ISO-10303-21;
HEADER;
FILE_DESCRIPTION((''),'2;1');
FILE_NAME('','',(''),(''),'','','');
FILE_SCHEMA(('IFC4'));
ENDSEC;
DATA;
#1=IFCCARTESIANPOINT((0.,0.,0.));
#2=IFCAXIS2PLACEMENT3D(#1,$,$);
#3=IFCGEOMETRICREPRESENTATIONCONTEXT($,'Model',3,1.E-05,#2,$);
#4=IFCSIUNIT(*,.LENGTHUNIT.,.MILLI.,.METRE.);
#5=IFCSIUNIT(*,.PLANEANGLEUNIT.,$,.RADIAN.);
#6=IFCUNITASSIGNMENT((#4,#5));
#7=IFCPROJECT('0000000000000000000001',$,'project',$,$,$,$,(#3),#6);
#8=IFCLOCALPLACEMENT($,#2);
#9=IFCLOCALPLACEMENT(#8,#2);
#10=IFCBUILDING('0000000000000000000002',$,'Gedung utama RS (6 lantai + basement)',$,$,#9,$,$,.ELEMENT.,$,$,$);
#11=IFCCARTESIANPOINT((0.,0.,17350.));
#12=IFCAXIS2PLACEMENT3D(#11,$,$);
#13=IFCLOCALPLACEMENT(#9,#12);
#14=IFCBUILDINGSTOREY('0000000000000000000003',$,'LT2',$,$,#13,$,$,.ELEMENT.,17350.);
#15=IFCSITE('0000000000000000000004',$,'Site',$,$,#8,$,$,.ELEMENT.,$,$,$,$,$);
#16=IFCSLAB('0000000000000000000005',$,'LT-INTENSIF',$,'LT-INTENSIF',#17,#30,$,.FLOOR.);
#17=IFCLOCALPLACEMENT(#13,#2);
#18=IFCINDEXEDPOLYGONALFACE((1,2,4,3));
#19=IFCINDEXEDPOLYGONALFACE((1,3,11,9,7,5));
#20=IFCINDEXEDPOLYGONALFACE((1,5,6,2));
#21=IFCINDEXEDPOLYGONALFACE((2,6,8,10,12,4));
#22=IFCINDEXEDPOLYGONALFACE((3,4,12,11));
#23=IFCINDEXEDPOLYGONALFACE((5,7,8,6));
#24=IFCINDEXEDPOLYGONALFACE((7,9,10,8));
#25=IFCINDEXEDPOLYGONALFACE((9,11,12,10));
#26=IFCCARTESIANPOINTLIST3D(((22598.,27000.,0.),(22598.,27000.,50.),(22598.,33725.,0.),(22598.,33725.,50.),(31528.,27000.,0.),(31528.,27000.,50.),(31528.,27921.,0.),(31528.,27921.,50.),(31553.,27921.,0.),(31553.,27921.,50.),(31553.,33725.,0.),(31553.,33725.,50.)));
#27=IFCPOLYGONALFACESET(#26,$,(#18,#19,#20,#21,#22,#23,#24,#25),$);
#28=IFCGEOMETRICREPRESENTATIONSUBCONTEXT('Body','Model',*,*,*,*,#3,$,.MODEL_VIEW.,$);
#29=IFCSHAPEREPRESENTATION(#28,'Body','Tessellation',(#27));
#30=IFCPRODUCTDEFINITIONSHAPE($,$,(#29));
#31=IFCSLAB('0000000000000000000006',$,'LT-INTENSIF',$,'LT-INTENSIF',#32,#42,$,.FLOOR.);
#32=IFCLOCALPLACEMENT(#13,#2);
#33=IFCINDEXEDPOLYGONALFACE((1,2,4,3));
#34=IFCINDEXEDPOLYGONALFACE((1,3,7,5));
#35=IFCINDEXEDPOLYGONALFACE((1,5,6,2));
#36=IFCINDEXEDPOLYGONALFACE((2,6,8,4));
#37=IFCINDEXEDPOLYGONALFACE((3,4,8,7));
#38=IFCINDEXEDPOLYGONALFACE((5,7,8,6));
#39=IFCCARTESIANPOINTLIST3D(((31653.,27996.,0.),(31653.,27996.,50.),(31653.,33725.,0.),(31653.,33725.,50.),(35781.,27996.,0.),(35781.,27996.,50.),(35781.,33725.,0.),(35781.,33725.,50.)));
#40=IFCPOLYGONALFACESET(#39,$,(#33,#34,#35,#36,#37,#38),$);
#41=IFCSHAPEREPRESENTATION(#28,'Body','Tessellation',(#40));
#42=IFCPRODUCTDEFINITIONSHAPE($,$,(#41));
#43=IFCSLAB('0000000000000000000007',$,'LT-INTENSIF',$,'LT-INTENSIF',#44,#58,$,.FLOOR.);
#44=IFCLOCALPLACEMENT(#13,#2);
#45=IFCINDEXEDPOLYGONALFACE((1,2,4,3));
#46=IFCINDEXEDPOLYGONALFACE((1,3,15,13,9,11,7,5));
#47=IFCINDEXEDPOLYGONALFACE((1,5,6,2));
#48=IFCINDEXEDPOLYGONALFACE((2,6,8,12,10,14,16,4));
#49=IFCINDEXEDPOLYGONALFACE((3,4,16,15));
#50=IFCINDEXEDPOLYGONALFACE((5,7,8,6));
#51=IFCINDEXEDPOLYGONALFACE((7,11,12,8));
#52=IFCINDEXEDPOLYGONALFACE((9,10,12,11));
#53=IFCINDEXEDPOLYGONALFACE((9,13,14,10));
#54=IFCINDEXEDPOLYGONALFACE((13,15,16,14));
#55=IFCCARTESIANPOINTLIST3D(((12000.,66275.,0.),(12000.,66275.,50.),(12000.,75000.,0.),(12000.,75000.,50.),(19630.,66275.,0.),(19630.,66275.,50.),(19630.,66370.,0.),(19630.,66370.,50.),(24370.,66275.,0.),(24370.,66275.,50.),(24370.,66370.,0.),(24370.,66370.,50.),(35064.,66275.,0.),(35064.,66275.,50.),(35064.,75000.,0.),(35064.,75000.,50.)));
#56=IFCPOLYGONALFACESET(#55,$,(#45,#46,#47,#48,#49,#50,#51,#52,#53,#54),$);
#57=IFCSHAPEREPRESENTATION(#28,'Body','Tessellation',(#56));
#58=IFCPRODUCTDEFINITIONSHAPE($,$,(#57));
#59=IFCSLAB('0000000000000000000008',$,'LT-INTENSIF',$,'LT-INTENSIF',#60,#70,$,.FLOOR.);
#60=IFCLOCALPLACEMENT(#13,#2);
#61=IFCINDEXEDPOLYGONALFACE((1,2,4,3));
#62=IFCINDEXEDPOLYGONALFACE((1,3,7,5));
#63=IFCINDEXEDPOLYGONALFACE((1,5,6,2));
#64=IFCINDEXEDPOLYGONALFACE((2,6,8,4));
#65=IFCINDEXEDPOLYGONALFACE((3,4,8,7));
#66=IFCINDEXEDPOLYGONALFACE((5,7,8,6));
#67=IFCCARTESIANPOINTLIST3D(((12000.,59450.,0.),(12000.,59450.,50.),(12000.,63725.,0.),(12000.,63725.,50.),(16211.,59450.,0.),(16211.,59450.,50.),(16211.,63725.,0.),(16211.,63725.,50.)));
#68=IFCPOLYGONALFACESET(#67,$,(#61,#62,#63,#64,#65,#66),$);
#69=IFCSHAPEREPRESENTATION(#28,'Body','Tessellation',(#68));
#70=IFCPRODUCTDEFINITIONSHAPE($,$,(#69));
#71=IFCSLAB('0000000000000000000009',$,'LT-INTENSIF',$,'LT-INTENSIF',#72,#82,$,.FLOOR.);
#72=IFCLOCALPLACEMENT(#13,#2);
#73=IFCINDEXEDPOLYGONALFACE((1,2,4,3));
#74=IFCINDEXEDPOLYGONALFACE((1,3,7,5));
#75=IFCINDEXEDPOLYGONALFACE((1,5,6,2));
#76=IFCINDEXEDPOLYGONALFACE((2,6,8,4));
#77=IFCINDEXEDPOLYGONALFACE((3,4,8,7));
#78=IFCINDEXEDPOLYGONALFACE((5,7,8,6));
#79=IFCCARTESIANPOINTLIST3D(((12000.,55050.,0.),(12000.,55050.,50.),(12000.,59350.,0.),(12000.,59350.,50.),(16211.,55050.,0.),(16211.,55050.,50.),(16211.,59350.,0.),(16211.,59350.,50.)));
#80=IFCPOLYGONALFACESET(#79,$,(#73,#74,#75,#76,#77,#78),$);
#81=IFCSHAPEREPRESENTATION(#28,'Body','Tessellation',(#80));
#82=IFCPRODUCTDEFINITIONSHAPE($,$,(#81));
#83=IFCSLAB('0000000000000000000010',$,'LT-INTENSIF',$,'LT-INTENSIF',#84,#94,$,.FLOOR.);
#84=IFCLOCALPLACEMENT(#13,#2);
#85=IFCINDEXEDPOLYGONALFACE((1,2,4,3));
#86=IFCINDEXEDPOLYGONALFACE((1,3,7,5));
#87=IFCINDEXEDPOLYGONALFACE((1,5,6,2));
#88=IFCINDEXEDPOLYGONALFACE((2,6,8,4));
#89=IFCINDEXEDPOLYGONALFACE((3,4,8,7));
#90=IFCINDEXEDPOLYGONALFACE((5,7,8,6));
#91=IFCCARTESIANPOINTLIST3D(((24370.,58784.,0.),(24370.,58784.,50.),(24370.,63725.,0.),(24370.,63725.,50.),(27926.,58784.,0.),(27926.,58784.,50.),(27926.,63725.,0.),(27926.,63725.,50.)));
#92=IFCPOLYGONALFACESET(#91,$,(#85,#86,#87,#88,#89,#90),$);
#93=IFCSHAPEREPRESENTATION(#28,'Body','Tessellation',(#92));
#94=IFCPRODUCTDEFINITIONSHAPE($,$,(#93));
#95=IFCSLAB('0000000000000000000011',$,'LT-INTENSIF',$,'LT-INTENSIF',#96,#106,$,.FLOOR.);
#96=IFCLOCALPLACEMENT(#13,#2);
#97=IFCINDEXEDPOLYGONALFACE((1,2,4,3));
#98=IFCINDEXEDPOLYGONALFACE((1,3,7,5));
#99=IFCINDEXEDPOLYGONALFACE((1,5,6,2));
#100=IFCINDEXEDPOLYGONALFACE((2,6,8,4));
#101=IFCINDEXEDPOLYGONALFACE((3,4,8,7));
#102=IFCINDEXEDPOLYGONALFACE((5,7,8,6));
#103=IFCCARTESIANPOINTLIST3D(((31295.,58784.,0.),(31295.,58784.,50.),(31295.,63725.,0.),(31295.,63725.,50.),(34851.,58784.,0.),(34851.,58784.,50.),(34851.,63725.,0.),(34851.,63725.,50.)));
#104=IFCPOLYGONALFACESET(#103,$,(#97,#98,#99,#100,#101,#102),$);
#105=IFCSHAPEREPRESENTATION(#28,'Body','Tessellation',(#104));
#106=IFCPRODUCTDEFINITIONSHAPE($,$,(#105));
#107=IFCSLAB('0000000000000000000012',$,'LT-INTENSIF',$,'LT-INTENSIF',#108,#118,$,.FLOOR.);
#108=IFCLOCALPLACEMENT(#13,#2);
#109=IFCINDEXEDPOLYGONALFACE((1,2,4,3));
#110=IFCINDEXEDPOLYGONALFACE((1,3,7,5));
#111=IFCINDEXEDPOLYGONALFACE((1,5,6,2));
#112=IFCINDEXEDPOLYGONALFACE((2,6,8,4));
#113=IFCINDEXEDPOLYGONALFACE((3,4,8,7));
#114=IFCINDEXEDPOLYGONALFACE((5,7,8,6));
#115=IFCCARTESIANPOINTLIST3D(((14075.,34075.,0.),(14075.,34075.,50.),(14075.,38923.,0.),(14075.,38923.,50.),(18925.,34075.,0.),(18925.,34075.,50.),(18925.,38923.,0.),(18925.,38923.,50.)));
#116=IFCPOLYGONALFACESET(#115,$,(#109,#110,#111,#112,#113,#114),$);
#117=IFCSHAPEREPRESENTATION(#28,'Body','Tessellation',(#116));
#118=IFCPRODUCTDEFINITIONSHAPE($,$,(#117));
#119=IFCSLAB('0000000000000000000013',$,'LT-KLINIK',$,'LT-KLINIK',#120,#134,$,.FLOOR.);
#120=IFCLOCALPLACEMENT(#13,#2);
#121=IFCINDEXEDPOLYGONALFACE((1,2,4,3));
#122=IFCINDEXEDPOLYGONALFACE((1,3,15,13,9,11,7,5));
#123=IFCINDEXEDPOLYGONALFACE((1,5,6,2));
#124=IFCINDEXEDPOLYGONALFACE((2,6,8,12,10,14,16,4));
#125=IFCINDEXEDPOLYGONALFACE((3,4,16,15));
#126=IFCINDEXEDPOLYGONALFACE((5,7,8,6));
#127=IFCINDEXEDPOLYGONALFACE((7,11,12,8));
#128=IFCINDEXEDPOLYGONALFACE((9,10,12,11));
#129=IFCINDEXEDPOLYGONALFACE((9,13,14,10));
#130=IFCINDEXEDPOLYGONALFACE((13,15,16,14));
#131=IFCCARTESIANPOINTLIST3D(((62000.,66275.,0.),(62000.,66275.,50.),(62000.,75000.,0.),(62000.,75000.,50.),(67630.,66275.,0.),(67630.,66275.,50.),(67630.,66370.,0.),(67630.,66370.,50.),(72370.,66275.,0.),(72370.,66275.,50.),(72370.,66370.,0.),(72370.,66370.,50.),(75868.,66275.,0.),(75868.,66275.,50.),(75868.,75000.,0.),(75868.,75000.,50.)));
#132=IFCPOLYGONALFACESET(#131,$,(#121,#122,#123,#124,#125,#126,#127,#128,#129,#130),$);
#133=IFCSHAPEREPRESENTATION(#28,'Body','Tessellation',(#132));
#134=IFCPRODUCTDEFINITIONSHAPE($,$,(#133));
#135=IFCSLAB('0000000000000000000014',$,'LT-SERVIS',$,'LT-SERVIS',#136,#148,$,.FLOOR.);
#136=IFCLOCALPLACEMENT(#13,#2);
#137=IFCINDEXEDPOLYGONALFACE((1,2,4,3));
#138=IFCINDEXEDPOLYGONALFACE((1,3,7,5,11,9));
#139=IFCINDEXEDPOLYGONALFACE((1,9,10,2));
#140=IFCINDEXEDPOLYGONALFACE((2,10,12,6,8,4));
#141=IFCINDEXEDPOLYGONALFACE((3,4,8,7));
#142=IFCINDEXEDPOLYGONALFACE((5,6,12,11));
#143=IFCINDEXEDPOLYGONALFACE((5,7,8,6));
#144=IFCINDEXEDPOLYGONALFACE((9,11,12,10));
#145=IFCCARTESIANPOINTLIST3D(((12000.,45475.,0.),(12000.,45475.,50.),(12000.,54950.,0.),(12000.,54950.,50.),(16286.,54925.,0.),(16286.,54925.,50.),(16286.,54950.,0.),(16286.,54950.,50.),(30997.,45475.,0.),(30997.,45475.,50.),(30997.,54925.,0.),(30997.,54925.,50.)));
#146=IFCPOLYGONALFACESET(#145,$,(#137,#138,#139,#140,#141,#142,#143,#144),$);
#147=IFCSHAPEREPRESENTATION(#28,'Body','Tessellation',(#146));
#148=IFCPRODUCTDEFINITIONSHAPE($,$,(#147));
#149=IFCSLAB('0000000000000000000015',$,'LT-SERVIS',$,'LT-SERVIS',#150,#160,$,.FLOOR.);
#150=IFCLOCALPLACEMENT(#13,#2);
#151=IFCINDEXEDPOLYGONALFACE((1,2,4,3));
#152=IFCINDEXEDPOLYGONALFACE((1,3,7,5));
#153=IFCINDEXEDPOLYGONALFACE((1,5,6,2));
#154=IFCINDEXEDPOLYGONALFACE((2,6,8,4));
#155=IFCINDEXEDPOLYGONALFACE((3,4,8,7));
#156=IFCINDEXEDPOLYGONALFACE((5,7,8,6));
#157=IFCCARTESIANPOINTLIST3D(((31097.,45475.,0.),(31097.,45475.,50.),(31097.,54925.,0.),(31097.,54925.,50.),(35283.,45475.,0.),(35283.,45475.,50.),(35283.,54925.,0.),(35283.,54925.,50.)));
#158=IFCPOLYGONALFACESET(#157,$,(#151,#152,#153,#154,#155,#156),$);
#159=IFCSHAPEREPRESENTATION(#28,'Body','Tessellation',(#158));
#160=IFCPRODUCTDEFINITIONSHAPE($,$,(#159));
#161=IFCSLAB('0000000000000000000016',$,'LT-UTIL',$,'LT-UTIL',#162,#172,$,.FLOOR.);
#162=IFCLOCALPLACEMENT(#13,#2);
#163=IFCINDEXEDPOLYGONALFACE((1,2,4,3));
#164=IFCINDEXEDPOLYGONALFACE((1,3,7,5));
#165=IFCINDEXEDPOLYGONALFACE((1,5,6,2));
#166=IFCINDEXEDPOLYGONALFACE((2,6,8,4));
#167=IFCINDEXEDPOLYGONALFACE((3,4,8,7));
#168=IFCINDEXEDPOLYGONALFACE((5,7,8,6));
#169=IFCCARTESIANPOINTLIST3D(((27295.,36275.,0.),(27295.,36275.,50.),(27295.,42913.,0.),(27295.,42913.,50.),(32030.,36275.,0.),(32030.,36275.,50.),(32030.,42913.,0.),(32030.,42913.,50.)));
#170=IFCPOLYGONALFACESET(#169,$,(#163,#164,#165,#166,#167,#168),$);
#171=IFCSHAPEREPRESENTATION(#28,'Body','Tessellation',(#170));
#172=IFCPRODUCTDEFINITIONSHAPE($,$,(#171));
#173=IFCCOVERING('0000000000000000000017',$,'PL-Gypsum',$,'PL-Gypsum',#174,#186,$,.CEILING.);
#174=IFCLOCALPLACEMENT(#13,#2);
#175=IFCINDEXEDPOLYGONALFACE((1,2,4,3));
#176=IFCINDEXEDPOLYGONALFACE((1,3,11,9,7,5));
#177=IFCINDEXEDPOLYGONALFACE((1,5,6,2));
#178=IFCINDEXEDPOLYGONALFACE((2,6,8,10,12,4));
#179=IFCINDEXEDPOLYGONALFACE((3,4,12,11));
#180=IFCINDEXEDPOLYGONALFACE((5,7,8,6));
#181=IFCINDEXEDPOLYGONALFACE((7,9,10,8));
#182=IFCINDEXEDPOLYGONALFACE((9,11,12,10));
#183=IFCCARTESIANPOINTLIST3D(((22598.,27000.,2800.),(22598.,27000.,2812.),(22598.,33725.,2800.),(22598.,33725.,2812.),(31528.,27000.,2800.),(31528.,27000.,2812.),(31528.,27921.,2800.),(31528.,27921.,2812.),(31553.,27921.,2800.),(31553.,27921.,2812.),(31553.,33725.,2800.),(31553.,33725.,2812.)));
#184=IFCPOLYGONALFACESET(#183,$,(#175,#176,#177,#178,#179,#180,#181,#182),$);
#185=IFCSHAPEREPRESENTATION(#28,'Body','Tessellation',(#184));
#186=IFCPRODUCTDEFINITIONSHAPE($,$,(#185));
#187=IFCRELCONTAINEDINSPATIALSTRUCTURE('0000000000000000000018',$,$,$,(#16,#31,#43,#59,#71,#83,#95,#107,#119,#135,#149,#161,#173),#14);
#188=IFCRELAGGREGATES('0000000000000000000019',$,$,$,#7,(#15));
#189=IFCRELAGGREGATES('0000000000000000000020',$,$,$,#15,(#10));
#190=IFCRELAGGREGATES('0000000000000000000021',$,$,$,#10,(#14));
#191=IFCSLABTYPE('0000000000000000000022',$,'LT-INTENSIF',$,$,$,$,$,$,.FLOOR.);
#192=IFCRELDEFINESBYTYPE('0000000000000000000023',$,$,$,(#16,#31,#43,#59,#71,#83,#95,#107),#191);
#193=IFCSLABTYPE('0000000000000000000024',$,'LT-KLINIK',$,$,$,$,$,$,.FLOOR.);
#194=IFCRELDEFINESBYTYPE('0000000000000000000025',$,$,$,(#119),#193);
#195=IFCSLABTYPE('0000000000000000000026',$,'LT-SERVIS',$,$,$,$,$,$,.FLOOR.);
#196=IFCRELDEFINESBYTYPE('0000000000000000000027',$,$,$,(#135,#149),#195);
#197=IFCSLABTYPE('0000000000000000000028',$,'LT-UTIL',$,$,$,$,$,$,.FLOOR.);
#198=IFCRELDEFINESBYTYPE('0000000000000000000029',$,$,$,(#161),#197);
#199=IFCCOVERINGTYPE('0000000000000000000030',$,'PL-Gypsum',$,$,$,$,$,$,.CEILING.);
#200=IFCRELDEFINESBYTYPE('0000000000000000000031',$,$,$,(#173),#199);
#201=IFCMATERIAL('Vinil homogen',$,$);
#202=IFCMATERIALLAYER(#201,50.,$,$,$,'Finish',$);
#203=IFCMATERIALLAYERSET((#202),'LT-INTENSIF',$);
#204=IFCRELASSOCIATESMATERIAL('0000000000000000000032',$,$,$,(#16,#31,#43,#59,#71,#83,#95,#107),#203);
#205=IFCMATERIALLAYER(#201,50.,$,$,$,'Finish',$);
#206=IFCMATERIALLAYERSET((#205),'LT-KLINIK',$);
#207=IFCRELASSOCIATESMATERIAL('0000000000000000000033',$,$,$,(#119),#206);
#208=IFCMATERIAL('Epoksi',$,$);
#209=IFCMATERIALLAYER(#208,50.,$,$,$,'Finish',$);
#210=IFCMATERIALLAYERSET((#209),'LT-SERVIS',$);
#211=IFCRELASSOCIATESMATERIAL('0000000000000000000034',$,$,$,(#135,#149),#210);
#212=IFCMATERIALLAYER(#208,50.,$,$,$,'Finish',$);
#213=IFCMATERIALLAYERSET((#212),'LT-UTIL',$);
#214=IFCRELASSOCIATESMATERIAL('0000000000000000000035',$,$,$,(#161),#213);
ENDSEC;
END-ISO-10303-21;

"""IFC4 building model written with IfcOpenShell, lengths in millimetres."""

from ifc_helpers import new_model, si_unit, frame, origin, place, context, subcontext, project, spatial, polyline, outline, extrude, material, layer, layer_set, layer_usage, type_object, element, save


model = new_model("IFC4")

# Units and contexts
model_context = context("Model", 3, precision=1e-05, world=origin())
body_context = subcontext(model_context, "Body", "Model", "MODEL_VIEW")
ifc_project = project(units=[si_unit("LENGTHUNIT", "METRE", prefix="MILLI"), si_unit("PLANEANGLEUNIT", "RADIAN")], contexts=[model_context])

# Site, building, storey
site_placement = place(None, origin())
site = spatial("IfcSite", under=ifc_project, at=site_placement, Name="Site", CompositionType="ELEMENT")
building_placement = place(site_placement, origin())
building = spatial("IfcBuilding", under=site, at=building_placement, Name="Gedung utama RS (6 lantai + basement)", CompositionType="ELEMENT")
storey_placement = place(building_placement, frame((0.0, 0.0, 17350.0)))
storey = spatial("IfcBuildingStorey", under=building, at=storey_placement, Name="LT2", CompositionType="ELEMENT", Elevation=17350.0)

# Slabs
ifc_material_1 = material(Name="Vinil homogen")
ifc_layer_1 = layer(ifc_material_1, 50.0, Category="Finish")
ifc_layer_set_1 = layer_set([ifc_layer_1], Name="LT-INTENSIF")
ifc_layer_usage_1 = layer_usage(ifc_layer_set_1, "AXIS3", "NEGATIVE", 50.0)
slab_type_1 = type_object("IfcSlabType", Name="LT-INTENSIF", PredefinedType="FLOOR")
slab_1_placement = place(storey_placement, origin())
element("IfcSlab", 1, at=slab_1_placement, inside=storey, type_object=slab_type_1, material=ifc_layer_usage_1, Name="LT-INTENSIF", ObjectType="LT-INTENSIF", PredefinedType="FLOOR", context=body_context, shape_type="SweptSolid", body=[
    extrude(outline(polyline([(22598.0, 27000.0), (31528.0, 27000.0), (31528.0, 27921.0), (31553.0, 27921.0), (31553.0, 33725.0), (22598.0, 33725.0), (22598.0, 27000.0)])), origin(), (0.0, 0.0, 1.0), 50.0),
])
slab_2_placement = place(storey_placement, origin())
element("IfcSlab", 2, at=slab_2_placement, inside=storey, type_object=slab_type_1, material=ifc_layer_usage_1, Name="LT-INTENSIF", ObjectType="LT-INTENSIF", PredefinedType="FLOOR", context=body_context, shape_type="SweptSolid", body=[
    extrude(outline(polyline([(31653.0, 27996.0), (35781.0, 27996.0), (35781.0, 33725.0), (31653.0, 33725.0), (31653.0, 27996.0)])), origin(), (0.0, 0.0, 1.0), 50.0),
])
slab_3_placement = place(storey_placement, origin())
element("IfcSlab", 3, at=slab_3_placement, inside=storey, type_object=slab_type_1, material=ifc_layer_usage_1, Name="LT-INTENSIF", ObjectType="LT-INTENSIF", PredefinedType="FLOOR", context=body_context, shape_type="SweptSolid", body=[
    extrude(outline(polyline([(12000.0, 66275.0), (19630.0, 66275.0), (19630.0, 66370.0), (24370.0, 66370.0), (24370.0, 66275.0), (35064.0, 66275.0), (35064.0, 75000.0), (12000.0, 75000.0), (12000.0, 66275.0)])), origin(), (0.0, 0.0, 1.0), 50.0),
])
slab_4_placement = place(storey_placement, origin())
element("IfcSlab", 4, at=slab_4_placement, inside=storey, type_object=slab_type_1, material=ifc_layer_usage_1, Name="LT-INTENSIF", ObjectType="LT-INTENSIF", PredefinedType="FLOOR", context=body_context, shape_type="SweptSolid", body=[
    extrude(outline(polyline([(12000.0, 59450.0), (16211.0, 59450.0), (16211.0, 63725.0), (12000.0, 63725.0), (12000.0, 59450.0)])), origin(), (0.0, 0.0, 1.0), 50.0),
])
slab_5_placement = place(storey_placement, origin())
element("IfcSlab", 5, at=slab_5_placement, inside=storey, type_object=slab_type_1, material=ifc_layer_usage_1, Name="LT-INTENSIF", ObjectType="LT-INTENSIF", PredefinedType="FLOOR", context=body_context, shape_type="SweptSolid", body=[
    extrude(outline(polyline([(12000.0, 55050.0), (16211.0, 55050.0), (16211.0, 59350.0), (12000.0, 59350.0), (12000.0, 55050.0)])), origin(), (0.0, 0.0, 1.0), 50.0),
])
slab_6_placement = place(storey_placement, origin())
element("IfcSlab", 6, at=slab_6_placement, inside=storey, type_object=slab_type_1, material=ifc_layer_usage_1, Name="LT-INTENSIF", ObjectType="LT-INTENSIF", PredefinedType="FLOOR", context=body_context, shape_type="SweptSolid", body=[
    extrude(outline(polyline([(24370.0, 58784.0), (27926.0, 58784.0), (27926.0, 63725.0), (24370.0, 63725.0), (24370.0, 58784.0)])), origin(), (0.0, 0.0, 1.0), 50.0),
])
slab_7_placement = place(storey_placement, origin())
element("IfcSlab", 7, at=slab_7_placement, inside=storey, type_object=slab_type_1, material=ifc_layer_usage_1, Name="LT-INTENSIF", ObjectType="LT-INTENSIF", PredefinedType="FLOOR", context=body_context, shape_type="SweptSolid", body=[
    extrude(outline(polyline([(31295.0, 58784.0), (34851.0, 58784.0), (34851.0, 63725.0), (31295.0, 63725.0), (31295.0, 58784.0)])), origin(), (0.0, 0.0, 1.0), 50.0),
])
slab_8_placement = place(storey_placement, origin())
element("IfcSlab", 8, at=slab_8_placement, inside=storey, type_object=slab_type_1, material=ifc_layer_usage_1, Name="LT-INTENSIF", ObjectType="LT-INTENSIF", PredefinedType="FLOOR", context=body_context, shape_type="SweptSolid", body=[
    extrude(outline(polyline([(14075.0, 34075.0), (18925.0, 34075.0), (18925.0, 38923.0), (14075.0, 38923.0), (14075.0, 34075.0)])), origin(), (0.0, 0.0, 1.0), 50.0),
])
ifc_layer_2 = layer(ifc_material_1, 50.0, Category="Finish")
ifc_layer_set_2 = layer_set([ifc_layer_2], Name="LT-KLINIK")
ifc_layer_usage_2 = layer_usage(ifc_layer_set_2, "AXIS3", "NEGATIVE", 50.0)
slab_type_2 = type_object("IfcSlabType", Name="LT-KLINIK", PredefinedType="FLOOR")
slab_9_placement = place(storey_placement, origin())
element("IfcSlab", 9, at=slab_9_placement, inside=storey, type_object=slab_type_2, material=ifc_layer_usage_2, Name="LT-KLINIK", ObjectType="LT-KLINIK", PredefinedType="FLOOR", context=body_context, shape_type="SweptSolid", body=[
    extrude(outline(polyline([(62000.0, 66275.0), (67630.0, 66275.0), (67630.0, 66370.0), (72370.0, 66370.0), (72370.0, 66275.0), (75868.0, 66275.0), (75868.0, 75000.0), (62000.0, 75000.0), (62000.0, 66275.0)])), origin(), (0.0, 0.0, 1.0), 50.0),
])
ifc_material_2 = material(Name="Epoksi")
ifc_layer_3 = layer(ifc_material_2, 50.0, Category="Finish")
ifc_layer_set_3 = layer_set([ifc_layer_3], Name="LT-SERVIS")
ifc_layer_usage_3 = layer_usage(ifc_layer_set_3, "AXIS3", "NEGATIVE", 50.0)
slab_type_3 = type_object("IfcSlabType", Name="LT-SERVIS", PredefinedType="FLOOR")
slab_10_placement = place(storey_placement, origin())
element("IfcSlab", 10, at=slab_10_placement, inside=storey, type_object=slab_type_3, material=ifc_layer_usage_3, Name="LT-SERVIS", ObjectType="LT-SERVIS", PredefinedType="FLOOR", context=body_context, shape_type="SweptSolid", body=[
    extrude(outline(polyline([(12000.0, 45475.0), (30997.0, 45475.0), (30997.0, 54925.0), (16286.0, 54925.0), (16286.0, 54950.0), (12000.0, 54950.0), (12000.0, 45475.0)])), origin(), (0.0, 0.0, 1.0), 50.0),
])
slab_11_placement = place(storey_placement, origin())
element("IfcSlab", 11, at=slab_11_placement, inside=storey, type_object=slab_type_3, material=ifc_layer_usage_3, Name="LT-SERVIS", ObjectType="LT-SERVIS", PredefinedType="FLOOR", context=body_context, shape_type="SweptSolid", body=[
    extrude(outline(polyline([(31097.0, 45475.0), (35283.0, 45475.0), (35283.0, 54925.0), (31097.0, 54925.0), (31097.0, 45475.0)])), origin(), (0.0, 0.0, 1.0), 50.0),
])
ifc_layer_4 = layer(ifc_material_2, 50.0, Category="Finish")
ifc_layer_set_4 = layer_set([ifc_layer_4], Name="LT-UTIL")
ifc_layer_usage_4 = layer_usage(ifc_layer_set_4, "AXIS3", "NEGATIVE", 50.0)
slab_type_4 = type_object("IfcSlabType", Name="LT-UTIL", PredefinedType="FLOOR")
slab_12_placement = place(storey_placement, origin())
element("IfcSlab", 12, at=slab_12_placement, inside=storey, type_object=slab_type_4, material=ifc_layer_usage_4, Name="LT-UTIL", ObjectType="LT-UTIL", PredefinedType="FLOOR", context=body_context, shape_type="SweptSolid", body=[
    extrude(outline(polyline([(27295.0, 36275.0), (32030.0, 36275.0), (32030.0, 42913.0), (27295.0, 42913.0), (27295.0, 36275.0)])), origin(), (0.0, 0.0, 1.0), 50.0),
])

# Covering
covering_type = type_object("IfcCoveringType", Name="PL-Gypsum", PredefinedType="CEILING")
covering_1_placement = place(storey_placement, origin())
element("IfcCovering", 13, at=covering_1_placement, inside=storey, type_object=covering_type, Name="PL-Gypsum", ObjectType="PL-Gypsum", PredefinedType="CEILING", context=body_context, shape_type="SweptSolid", body=[
    extrude(outline(polyline([(22598.0, 27000.0), (31528.0, 27000.0), (31528.0, 27921.0), (31553.0, 27921.0), (31553.0, 33725.0), (22598.0, 33725.0), (22598.0, 27000.0)])), frame((0.0, 0.0, 2800.0)), (0.0, 0.0, 1.0), 12.0),
])

save(model, "model.ifc")
